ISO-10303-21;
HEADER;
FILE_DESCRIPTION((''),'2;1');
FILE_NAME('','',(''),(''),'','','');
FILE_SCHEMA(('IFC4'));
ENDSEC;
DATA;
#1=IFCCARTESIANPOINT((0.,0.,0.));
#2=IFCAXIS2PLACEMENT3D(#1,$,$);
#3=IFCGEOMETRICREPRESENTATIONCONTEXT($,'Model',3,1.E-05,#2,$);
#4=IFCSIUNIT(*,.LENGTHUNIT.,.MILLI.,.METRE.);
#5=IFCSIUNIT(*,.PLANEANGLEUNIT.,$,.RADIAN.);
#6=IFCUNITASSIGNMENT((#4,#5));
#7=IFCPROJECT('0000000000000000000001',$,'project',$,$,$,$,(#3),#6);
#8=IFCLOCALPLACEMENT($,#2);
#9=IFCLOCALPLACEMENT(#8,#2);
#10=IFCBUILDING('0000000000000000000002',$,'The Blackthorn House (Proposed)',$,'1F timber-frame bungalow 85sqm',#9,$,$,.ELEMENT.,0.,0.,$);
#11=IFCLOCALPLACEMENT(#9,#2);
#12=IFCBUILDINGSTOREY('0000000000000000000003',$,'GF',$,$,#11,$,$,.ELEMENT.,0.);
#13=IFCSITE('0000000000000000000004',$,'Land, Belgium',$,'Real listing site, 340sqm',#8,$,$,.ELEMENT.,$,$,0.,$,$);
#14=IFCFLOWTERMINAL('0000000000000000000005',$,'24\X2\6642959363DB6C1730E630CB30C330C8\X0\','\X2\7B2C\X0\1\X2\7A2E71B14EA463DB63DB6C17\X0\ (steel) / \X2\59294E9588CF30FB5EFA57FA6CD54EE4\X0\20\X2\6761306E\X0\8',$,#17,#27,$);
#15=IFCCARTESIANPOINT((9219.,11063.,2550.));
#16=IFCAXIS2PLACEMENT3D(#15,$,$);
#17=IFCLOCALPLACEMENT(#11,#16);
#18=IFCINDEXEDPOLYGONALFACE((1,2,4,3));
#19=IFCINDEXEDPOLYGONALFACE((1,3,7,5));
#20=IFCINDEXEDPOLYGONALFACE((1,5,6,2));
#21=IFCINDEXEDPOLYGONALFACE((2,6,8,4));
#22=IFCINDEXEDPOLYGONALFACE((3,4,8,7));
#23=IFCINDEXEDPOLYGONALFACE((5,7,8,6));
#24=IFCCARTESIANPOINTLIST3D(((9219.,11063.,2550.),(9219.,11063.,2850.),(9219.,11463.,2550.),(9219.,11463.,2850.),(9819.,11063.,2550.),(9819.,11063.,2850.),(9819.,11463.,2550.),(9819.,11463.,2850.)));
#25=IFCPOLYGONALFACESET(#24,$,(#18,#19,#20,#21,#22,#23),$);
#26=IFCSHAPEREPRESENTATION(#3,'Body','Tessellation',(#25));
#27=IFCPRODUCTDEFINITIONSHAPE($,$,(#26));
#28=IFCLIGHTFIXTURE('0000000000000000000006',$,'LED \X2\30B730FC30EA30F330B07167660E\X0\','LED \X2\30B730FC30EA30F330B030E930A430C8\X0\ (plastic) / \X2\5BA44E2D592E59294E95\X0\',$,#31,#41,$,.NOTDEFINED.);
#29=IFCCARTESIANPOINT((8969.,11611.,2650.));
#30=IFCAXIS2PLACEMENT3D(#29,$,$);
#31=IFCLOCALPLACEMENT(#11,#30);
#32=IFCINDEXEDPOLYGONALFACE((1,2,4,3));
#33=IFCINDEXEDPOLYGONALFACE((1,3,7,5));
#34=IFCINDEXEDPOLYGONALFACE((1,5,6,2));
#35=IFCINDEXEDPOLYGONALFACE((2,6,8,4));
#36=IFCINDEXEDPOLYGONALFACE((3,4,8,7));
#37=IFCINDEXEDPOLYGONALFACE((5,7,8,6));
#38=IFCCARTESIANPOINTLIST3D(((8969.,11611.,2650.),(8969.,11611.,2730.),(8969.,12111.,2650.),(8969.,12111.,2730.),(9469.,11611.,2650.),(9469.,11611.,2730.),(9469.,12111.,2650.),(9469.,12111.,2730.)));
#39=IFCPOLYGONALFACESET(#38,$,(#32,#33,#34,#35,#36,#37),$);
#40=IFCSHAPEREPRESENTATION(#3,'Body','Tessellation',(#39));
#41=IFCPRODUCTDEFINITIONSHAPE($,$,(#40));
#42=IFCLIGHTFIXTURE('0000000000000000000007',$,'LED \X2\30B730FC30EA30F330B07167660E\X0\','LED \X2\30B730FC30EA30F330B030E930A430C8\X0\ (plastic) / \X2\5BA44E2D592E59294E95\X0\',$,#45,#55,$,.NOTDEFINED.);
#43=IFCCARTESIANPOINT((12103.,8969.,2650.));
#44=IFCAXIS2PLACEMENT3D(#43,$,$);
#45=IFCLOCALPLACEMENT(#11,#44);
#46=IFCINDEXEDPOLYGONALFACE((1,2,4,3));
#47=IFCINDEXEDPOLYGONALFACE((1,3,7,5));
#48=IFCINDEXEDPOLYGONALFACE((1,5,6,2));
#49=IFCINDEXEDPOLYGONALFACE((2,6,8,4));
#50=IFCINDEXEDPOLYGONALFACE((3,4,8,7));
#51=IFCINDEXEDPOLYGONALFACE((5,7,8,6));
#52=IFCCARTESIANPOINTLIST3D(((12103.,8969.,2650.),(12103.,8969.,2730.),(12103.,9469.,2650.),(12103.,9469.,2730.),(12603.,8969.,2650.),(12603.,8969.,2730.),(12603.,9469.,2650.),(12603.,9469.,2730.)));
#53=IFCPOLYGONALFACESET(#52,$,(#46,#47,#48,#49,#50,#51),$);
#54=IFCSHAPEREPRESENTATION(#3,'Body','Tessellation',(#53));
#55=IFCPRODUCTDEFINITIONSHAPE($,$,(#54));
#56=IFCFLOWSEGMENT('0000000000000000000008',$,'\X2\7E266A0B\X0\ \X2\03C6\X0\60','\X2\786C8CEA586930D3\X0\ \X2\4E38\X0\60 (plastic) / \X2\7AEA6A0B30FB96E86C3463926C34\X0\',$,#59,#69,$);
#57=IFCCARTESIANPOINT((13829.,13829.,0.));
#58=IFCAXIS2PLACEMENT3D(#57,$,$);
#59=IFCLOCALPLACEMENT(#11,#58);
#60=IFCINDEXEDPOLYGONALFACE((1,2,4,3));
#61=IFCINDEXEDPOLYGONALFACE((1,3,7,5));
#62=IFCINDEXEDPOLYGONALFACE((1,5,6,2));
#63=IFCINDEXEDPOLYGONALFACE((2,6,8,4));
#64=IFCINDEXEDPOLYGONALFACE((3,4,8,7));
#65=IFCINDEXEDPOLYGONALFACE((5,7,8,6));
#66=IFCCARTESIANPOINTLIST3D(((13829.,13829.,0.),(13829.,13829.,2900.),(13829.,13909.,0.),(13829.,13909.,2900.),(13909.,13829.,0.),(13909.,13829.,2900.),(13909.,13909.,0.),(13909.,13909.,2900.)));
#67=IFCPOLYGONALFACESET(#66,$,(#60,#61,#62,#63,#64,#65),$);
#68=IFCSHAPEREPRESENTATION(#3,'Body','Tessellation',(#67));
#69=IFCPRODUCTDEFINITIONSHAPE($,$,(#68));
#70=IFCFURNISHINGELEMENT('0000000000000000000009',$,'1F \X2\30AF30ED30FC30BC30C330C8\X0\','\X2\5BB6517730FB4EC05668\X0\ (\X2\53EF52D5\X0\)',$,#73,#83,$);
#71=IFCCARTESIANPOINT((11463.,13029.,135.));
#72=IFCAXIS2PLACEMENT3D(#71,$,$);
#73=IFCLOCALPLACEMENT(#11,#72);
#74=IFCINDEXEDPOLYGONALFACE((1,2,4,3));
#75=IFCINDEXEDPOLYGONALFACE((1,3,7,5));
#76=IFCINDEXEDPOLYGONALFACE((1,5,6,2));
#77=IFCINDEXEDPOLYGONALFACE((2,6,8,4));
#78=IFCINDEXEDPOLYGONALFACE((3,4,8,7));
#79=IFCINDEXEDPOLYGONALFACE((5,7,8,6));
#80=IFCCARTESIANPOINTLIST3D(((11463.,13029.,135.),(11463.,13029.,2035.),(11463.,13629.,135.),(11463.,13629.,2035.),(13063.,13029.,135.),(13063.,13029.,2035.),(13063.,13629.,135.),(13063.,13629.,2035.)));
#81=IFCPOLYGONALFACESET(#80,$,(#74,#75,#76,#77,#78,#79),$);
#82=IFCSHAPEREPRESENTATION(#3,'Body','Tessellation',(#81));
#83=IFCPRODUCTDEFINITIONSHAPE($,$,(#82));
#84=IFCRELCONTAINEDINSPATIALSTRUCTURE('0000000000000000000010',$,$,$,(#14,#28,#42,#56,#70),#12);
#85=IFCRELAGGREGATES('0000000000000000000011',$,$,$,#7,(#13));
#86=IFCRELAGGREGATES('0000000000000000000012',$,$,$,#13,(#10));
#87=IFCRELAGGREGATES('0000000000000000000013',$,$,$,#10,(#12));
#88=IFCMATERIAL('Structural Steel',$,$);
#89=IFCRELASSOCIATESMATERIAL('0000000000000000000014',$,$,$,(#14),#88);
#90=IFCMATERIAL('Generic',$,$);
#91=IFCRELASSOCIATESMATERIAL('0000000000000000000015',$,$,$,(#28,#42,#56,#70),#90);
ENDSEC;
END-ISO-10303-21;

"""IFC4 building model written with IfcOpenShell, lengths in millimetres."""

from ifc_helpers import new_model, si_unit, frame, frame_2d, origin, place, context, project, spatial, rectangle, extrude, material, element, save


model = new_model("IFC4")

# Units and contexts
model_context = context("Model", 3, precision=1e-05, world=origin())
ifc_project = project(units=[si_unit("LENGTHUNIT", "METRE", prefix="MILLI"), si_unit("PLANEANGLEUNIT", "RADIAN")], contexts=[model_context])

# Site, building, storey
site_placement = place(None, origin())
site = spatial("IfcSite", under=ifc_project, at=site_placement, Name="Land, Belgium", ObjectType="Real listing site, 340sqm", CompositionType="ELEMENT", RefElevation=0.0)
building_placement = place(site_placement, origin())
building = spatial("IfcBuilding", under=site, at=building_placement, Name="The Blackthorn House (Proposed)", ObjectType="1F timber-frame bungalow 85sqm", CompositionType="ELEMENT", ElevationOfRefHeight=0.0, ElevationOfTerrain=0.0)
storey_placement = place(building_placement, origin())
storey = spatial("IfcBuildingStorey", under=building, at=storey_placement, Name="GF", CompositionType="ELEMENT", Elevation=0.0)

# Shared definitions
ifc_material_1 = material(Name="Generic")

# Flow terminal
ifc_material_2 = material(Name="Structural Steel")
flow_terminal_placement = place(storey_placement, frame((9219.0, 11063.0, 2550.0)))
element("IfcFlowTerminal", 1, at=flow_terminal_placement, inside=storey, material=ifc_material_2, Name="24時間換気ユニット", Description="第1種熱交換換気 (steel) / 天井裏・建基法令20条の8", context=model_context, shape_type="SweptSolid", body=[
    extrude(rectangle(XDim=600.0, YDim=400.0, at=frame_2d((300.0, 200.0))), frame((9219.0, 11063.0, 2550.0)), (0.0, 0.0, 1.0), 300.0),
])

# Light fixtures
light_fixture_1_placement = place(storey_placement, frame((8969.0, 11611.0, 2650.0)))
element("IfcLightFixture", 2, at=light_fixture_1_placement, inside=storey, material=ifc_material_1, Name="LED シーリング照明", Description="LED シーリングライト (plastic) / 室中央天井", PredefinedType="NOTDEFINED", context=model_context, shape_type="SweptSolid", body=[
    extrude(rectangle(XDim=500.0, YDim=500.0, at=frame_2d((250.0, 250.0))), frame((8969.0, 11611.0, 2650.0)), (0.0, 0.0, 1.0), 80.0),
])
light_fixture_2_placement = place(storey_placement, frame((12103.0, 8969.0, 2650.0)))
element("IfcLightFixture", 3, at=light_fixture_2_placement, inside=storey, material=ifc_material_1, Name="LED シーリング照明", Description="LED シーリングライト (plastic) / 室中央天井", PredefinedType="NOTDEFINED", context=model_context, shape_type="SweptSolid", body=[
    extrude(rectangle(XDim=500.0, YDim=500.0, at=frame_2d((250.0, 250.0))), frame((12103.0, 8969.0, 2650.0)), (0.0, 0.0, 1.0), 80.0),
])

# Flow segment
flow_segment_placement = place(storey_placement, frame((13829.0, 13829.0, 0.0)))
element("IfcFlowSegment", 4, at=flow_segment_placement, inside=storey, material=ifc_material_1, Name="縦樋 φ60", Description="硬質塩ビ 丸60 (plastic) / 竪樋・雨水排水", context=model_context, shape_type="SweptSolid", body=[
    extrude(rectangle(XDim=80.0, YDim=80.0, at=frame_2d((40.0, 40.0))), frame((13829.0, 13829.0, 0.0)), (0.0, 0.0, 1.0), 2900.0),
])

# Furnishing element
furnishing_placement = place(storey_placement, frame((11463.0, 13029.0, 135.0)))
element("IfcFurnishingElement", 5, at=furnishing_placement, inside=storey, material=ifc_material_1, Name="1F クローゼット", Description="家具・什器 (可動)", context=model_context, shape_type="SweptSolid", body=[
    extrude(rectangle(XDim=1600.0, YDim=600.0, at=frame_2d((800.0, 300.0))), frame((11463.0, 13029.0, 135.0)), (0.0, 0.0, 1.0), 1900.0),
])

save(model, "model.ifc")
